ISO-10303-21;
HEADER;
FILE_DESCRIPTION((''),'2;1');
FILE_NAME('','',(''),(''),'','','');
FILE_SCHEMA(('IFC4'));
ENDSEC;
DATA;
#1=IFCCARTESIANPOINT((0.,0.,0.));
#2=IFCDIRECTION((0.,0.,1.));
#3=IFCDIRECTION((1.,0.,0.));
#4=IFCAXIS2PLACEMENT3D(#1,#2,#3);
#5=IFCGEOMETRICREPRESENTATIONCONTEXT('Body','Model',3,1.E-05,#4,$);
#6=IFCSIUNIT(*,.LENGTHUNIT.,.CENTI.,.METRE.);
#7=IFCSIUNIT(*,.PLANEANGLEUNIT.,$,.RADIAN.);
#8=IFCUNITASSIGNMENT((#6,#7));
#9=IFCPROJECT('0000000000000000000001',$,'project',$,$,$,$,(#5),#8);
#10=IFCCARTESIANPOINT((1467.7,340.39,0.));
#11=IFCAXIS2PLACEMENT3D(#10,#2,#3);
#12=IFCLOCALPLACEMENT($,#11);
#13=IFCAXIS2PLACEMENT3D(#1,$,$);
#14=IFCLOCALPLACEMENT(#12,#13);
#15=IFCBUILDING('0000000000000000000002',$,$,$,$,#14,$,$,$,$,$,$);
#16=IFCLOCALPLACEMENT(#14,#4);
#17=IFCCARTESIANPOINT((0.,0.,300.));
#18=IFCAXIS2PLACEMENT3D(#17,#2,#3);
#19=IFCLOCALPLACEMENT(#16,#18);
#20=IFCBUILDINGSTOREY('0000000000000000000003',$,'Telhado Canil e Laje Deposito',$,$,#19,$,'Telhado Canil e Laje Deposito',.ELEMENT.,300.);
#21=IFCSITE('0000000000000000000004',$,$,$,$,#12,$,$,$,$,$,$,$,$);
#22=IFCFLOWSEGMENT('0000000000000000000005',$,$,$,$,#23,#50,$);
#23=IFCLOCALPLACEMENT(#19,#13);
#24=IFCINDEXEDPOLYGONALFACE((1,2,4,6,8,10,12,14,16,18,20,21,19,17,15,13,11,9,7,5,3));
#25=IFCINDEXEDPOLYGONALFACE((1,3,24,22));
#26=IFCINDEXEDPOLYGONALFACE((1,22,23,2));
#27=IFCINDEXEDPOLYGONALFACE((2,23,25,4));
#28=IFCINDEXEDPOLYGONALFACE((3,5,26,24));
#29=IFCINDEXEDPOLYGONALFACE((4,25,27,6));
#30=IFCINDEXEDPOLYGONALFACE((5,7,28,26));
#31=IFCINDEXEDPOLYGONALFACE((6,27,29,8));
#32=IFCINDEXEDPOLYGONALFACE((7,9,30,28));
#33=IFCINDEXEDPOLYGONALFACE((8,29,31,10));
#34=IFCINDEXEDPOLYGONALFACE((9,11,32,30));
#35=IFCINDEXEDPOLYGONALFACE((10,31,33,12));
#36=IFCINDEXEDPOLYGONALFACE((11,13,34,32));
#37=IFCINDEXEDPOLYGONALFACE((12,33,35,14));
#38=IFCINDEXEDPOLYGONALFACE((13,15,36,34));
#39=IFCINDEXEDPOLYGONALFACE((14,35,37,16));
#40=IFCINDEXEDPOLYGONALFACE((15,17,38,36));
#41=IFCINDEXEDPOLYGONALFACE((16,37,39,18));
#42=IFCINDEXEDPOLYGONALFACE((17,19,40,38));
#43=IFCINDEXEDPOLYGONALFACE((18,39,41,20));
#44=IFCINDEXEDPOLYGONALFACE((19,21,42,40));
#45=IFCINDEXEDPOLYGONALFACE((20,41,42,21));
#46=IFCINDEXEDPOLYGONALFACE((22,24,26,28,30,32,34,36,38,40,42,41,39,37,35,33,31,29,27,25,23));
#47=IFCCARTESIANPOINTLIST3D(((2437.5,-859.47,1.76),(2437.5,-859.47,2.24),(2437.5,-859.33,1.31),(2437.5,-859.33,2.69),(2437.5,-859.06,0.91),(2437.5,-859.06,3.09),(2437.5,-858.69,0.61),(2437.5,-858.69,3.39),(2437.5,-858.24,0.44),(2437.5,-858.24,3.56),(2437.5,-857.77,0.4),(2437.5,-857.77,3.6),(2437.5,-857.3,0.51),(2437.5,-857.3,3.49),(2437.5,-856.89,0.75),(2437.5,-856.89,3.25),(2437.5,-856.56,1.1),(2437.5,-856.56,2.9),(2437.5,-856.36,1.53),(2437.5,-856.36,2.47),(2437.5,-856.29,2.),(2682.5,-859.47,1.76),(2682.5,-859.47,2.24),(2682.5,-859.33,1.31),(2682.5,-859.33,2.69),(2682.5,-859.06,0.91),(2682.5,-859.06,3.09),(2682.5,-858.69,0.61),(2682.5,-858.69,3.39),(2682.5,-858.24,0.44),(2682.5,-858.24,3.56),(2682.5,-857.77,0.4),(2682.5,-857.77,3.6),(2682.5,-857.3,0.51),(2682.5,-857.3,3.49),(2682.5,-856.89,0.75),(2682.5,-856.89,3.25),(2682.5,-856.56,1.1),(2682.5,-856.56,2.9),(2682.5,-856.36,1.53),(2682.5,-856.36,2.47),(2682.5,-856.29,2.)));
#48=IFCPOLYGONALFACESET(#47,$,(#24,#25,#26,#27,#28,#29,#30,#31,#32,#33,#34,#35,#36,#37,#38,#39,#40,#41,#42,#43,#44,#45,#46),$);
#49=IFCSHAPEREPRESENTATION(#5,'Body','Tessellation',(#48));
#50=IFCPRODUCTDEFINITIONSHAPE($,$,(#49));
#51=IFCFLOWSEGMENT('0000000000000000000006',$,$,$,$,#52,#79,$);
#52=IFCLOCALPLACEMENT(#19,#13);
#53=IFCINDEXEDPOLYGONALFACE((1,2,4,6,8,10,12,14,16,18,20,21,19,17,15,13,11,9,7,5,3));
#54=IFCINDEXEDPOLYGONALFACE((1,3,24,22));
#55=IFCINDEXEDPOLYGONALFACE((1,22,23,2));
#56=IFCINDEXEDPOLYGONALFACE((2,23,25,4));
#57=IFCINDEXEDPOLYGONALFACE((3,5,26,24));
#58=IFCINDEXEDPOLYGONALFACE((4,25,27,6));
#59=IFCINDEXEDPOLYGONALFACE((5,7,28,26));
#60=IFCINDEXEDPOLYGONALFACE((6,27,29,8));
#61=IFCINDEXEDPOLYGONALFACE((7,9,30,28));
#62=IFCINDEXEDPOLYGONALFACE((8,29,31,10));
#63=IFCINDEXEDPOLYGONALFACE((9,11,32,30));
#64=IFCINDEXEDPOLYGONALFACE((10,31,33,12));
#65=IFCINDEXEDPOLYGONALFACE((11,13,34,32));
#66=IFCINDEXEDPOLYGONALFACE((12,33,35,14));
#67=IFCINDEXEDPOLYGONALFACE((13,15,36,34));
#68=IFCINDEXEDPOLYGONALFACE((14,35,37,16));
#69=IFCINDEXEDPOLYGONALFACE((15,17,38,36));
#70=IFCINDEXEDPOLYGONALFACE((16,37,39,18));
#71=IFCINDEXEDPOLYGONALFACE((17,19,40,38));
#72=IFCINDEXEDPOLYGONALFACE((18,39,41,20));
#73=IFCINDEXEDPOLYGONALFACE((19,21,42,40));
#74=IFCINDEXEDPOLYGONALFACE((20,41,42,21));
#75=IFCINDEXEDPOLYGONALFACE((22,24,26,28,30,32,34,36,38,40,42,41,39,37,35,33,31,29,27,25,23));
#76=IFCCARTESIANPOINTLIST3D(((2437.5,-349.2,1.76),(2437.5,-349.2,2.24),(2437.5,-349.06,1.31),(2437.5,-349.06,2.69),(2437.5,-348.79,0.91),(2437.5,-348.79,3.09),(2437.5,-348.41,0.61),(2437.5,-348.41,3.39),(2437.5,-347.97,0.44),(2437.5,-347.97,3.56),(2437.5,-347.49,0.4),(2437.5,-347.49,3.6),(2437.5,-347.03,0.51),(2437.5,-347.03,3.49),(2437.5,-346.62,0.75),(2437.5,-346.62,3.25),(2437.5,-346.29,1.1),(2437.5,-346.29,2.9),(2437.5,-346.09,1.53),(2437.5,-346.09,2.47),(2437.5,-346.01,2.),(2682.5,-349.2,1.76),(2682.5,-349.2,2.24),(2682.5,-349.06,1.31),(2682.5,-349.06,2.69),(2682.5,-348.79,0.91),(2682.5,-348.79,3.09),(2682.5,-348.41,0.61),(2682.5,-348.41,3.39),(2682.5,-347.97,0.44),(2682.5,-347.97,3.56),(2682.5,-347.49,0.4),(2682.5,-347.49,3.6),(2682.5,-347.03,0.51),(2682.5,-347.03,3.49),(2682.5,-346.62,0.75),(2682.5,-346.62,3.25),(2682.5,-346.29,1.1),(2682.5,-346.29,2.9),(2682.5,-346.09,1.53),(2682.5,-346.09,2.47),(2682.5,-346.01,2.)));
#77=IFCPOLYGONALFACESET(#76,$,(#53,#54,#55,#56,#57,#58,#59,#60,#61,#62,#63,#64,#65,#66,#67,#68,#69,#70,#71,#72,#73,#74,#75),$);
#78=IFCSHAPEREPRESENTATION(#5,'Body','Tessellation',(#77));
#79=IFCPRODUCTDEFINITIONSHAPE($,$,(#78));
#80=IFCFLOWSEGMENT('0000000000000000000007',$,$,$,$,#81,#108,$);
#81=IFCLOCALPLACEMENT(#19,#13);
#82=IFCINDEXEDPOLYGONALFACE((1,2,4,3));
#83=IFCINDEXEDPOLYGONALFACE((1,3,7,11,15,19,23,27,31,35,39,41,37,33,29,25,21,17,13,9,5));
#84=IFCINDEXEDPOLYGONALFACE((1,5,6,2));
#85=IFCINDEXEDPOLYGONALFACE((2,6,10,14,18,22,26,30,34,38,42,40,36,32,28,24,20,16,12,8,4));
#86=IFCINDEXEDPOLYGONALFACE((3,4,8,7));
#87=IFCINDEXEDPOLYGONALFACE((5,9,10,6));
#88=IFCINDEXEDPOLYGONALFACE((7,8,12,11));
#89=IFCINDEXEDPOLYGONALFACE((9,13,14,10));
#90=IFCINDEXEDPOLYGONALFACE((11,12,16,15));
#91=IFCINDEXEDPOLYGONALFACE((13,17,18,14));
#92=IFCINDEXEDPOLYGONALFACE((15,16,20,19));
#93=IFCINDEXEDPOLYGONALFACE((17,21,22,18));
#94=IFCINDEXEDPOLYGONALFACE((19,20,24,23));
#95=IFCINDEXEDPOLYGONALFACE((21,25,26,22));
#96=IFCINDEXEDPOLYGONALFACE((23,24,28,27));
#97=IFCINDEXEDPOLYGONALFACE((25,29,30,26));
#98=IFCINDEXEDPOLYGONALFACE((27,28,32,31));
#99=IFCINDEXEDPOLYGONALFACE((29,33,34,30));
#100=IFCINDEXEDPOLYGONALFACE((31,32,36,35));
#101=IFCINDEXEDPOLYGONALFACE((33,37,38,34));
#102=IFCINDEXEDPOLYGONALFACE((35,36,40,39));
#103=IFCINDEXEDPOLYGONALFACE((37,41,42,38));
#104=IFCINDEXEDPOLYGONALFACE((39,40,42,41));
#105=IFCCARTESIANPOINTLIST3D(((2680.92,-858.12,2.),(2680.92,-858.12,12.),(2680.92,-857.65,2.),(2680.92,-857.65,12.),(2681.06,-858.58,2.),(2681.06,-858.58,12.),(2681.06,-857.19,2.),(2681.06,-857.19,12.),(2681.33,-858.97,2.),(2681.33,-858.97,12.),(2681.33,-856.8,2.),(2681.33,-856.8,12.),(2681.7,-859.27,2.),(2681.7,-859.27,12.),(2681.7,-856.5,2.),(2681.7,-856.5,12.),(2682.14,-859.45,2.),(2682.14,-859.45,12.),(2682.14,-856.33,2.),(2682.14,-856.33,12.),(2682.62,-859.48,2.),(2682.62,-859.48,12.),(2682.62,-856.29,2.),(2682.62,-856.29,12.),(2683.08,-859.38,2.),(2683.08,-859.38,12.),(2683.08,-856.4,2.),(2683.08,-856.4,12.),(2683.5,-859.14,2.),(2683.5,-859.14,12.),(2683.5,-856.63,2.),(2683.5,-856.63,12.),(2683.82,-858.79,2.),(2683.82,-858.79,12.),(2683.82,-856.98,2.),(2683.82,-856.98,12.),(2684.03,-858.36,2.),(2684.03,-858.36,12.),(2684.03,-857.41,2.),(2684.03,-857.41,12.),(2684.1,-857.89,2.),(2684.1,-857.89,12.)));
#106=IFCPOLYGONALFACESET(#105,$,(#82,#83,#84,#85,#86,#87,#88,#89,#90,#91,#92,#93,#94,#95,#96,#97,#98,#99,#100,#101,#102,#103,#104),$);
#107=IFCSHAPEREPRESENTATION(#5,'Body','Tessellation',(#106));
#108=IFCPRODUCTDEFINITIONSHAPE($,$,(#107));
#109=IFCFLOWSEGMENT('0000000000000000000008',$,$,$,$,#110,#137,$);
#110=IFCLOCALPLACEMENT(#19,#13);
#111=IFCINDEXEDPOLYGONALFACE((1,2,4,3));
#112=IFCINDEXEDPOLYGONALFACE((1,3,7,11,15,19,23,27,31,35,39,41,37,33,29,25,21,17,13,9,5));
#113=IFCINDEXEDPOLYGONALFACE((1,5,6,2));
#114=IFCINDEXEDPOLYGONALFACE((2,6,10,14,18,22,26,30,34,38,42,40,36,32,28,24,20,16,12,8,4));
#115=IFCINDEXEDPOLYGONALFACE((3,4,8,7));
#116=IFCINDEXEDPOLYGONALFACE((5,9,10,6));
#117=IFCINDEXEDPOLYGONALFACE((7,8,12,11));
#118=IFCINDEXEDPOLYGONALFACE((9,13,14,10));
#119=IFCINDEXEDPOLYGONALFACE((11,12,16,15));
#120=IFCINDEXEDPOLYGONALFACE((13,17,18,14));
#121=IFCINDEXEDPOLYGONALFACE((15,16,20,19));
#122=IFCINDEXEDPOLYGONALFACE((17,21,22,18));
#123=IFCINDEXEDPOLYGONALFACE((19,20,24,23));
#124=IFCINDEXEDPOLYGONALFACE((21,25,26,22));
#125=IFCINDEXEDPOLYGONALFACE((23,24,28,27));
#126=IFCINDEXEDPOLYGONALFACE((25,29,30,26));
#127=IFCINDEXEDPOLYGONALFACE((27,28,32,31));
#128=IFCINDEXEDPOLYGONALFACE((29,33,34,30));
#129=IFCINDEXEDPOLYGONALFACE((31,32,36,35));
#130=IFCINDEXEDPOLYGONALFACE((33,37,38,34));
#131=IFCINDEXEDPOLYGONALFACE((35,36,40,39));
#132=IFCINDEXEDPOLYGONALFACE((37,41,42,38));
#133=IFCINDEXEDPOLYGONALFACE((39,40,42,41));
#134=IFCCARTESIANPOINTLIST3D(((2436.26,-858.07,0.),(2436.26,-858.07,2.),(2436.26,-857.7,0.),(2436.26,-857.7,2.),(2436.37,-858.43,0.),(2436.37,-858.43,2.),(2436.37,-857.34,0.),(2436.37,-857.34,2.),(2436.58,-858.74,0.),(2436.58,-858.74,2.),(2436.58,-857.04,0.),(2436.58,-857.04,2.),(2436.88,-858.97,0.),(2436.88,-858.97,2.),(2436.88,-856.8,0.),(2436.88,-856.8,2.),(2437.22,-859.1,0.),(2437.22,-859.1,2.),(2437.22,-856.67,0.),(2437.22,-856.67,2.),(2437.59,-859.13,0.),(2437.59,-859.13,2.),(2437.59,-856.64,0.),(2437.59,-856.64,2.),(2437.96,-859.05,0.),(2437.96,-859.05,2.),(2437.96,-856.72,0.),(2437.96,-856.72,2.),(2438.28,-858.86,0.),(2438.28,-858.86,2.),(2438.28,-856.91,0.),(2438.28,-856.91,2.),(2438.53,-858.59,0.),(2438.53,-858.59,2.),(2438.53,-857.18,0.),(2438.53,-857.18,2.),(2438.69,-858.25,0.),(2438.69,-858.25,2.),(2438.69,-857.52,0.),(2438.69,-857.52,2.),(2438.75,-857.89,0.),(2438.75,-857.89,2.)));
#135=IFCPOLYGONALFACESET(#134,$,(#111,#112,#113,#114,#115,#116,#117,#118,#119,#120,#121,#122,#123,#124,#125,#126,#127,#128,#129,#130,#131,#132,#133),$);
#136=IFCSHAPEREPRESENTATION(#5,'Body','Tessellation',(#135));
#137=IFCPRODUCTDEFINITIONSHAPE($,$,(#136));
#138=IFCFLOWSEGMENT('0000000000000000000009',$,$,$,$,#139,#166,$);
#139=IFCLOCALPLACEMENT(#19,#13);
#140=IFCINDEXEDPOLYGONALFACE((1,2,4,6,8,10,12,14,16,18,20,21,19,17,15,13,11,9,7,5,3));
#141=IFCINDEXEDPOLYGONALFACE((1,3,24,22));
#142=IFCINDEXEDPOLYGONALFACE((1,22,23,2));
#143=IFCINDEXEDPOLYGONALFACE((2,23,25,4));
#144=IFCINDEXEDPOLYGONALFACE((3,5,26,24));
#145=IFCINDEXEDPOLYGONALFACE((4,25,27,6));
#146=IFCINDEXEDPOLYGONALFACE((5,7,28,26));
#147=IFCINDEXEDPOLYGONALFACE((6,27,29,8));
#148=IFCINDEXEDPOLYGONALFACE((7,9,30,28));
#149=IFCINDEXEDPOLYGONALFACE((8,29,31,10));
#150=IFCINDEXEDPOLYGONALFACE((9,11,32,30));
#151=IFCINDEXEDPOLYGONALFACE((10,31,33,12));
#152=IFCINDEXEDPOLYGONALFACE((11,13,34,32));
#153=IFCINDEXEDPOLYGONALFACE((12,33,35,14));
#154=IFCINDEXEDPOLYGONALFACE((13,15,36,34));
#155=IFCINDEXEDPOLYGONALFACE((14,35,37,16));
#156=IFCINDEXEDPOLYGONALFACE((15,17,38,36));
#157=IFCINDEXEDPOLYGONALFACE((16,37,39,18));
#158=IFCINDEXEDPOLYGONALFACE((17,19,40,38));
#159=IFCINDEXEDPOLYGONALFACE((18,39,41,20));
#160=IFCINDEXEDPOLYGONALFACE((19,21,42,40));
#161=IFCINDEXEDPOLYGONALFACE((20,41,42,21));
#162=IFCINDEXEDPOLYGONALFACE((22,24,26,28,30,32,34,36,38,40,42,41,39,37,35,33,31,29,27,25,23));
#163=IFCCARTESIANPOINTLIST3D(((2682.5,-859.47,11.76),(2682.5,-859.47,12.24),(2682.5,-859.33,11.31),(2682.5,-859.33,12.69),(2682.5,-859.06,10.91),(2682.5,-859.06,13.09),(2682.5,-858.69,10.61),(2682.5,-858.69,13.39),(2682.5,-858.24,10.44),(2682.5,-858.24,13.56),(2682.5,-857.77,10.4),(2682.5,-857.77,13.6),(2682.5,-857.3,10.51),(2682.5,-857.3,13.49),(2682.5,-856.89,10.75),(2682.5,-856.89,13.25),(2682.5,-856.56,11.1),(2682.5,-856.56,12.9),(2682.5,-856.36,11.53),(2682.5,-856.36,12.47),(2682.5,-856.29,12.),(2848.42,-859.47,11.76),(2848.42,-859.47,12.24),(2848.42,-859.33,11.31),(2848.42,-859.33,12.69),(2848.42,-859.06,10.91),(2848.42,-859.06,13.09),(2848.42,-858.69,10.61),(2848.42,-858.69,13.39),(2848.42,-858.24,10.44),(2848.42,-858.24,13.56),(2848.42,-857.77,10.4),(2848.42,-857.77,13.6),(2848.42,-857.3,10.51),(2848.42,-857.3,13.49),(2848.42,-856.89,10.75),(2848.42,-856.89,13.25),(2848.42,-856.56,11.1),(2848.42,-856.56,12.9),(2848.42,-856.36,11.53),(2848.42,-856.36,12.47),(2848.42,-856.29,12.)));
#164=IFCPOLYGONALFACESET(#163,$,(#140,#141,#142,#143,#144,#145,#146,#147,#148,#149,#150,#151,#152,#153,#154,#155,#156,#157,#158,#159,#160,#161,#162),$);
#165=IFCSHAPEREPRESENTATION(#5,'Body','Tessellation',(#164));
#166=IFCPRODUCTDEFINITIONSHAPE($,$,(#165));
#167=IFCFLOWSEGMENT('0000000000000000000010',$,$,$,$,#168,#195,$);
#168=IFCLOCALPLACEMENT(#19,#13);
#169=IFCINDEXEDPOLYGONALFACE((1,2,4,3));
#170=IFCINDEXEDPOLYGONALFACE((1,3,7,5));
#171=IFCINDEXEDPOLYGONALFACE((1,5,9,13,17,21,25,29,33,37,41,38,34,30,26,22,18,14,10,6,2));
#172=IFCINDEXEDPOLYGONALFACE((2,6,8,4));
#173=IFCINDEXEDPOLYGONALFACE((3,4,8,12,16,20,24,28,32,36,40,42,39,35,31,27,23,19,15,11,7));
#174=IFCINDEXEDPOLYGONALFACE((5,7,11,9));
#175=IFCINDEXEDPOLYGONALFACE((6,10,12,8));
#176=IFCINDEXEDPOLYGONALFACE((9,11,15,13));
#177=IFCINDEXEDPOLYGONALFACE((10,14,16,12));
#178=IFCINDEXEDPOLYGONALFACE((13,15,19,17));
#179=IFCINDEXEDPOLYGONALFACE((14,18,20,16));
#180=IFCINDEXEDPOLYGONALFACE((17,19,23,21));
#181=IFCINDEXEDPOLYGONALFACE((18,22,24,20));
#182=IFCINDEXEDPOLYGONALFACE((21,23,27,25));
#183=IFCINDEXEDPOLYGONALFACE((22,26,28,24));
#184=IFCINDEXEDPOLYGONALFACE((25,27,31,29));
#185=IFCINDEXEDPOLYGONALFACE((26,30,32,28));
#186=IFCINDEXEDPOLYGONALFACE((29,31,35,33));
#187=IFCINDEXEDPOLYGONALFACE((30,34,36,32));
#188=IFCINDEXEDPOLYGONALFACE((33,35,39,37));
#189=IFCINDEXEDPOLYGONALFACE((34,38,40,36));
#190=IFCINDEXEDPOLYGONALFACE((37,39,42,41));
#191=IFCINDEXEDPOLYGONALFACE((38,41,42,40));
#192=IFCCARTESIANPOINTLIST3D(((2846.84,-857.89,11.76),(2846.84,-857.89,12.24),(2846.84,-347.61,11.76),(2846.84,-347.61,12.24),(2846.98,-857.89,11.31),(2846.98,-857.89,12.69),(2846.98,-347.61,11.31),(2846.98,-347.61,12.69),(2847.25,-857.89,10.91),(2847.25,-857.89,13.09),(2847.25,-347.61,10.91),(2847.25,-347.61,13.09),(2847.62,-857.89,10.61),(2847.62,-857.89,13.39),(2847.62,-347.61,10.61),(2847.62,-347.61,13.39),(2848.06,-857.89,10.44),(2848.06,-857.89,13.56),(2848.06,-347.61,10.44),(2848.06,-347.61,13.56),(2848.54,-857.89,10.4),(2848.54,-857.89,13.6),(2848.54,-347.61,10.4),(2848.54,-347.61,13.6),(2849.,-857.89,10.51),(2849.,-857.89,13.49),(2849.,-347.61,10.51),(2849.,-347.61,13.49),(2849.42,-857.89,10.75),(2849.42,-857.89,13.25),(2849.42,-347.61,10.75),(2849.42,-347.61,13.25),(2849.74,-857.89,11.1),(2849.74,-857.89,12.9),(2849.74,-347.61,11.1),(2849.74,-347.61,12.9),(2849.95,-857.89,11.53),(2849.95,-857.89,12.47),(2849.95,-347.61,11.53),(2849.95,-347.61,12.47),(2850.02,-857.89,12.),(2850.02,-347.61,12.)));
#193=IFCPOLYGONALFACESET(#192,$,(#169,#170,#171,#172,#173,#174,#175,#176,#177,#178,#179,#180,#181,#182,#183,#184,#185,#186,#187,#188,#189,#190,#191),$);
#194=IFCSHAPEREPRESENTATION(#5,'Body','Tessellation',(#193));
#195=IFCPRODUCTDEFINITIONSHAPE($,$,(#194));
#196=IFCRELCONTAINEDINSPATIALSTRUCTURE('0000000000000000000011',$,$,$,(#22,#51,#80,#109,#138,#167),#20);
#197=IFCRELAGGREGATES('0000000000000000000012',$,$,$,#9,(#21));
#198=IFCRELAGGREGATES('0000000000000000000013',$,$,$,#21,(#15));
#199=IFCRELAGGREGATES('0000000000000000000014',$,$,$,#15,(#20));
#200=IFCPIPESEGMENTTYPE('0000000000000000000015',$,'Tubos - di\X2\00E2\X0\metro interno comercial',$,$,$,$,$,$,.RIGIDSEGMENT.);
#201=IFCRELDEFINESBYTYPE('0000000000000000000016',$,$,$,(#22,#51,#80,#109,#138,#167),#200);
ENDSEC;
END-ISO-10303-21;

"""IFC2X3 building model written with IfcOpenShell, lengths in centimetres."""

from ifc_helpers import new_model, si_unit, frame, origin, origin_with_axes, origin_2d_with_axis, place, context, project, spatial, circle, extrude, type_object, element, save


model = new_model("IFC2X3")

# Units and contexts
model_context = context("Model", 3, precision=1e-05, world=origin_with_axes(), identifier="Body")
ifc_project = project(units=[si_unit("LENGTHUNIT", "METRE", prefix="CENTI"), si_unit("PLANEANGLEUNIT", "RADIAN")], contexts=[model_context])

# Site, building, storey
site_placement = place(None, frame((1467.7, 340.39, 0.0), z_axis=(0.0, 0.0, 1.0), x_axis=(1.0, 0.0, 0.0)))
site = spatial("IfcSite", under=ifc_project, at=site_placement)
building_placement = place(site_placement, origin())
building = spatial("IfcBuilding", under=site, at=building_placement)
placement = place(building_placement, origin_with_axes())
storey_placement = place(placement, frame((0.0, 0.0, 300.0), z_axis=(0.0, 0.0, 1.0), x_axis=(1.0, 0.0, 0.0)))
storey = spatial("IfcBuildingStorey", under=building, at=storey_placement, Name="Telhado Canil e Laje Deposito", LongName="Telhado Canil e Laje Deposito", CompositionType="ELEMENT", Elevation=300.0)

# Flow segments
pipe_segment_type_1 = type_object("IfcPipeSegmentType", Name="Tubos - diâmetro interno comercial", PredefinedType="RIGIDSEGMENT")
for number, where, z_axis, x_axis in (
    (1, (2560.0, -857.89, 3.6), (0.0, 0.0, 1.0), (1.0, 0.0, 0.0)),
    (2, (2560.0, -347.61, 3.6), (0.0, 0.0, 1.0), (1.0, 0.0, 0.0)),
):
    element("IfcFlowSegment", number, at=place(storey_placement, frame(where, z_axis=z_axis, x_axis=x_axis)), inside=storey, type_object=pipe_segment_type_1, context=model_context, shape_type="SolidModel", body=[
        extrude(circle(Radius=1.6, at=origin_2d_with_axis()), frame((122.5, 0.0, -1.6), z_axis=(-1.0, 0.0, 0.0), x_axis=(0.0, 1.0, 0.0)), (0.0, 0.0, 1.0), 245.0),
    ])
flow_segment_1_placement = place(storey_placement, frame((2682.5, -857.89, 12.0), z_axis=(0.0, 0.0, 1.0), x_axis=(1.0, 0.0, 0.0)))
element("IfcFlowSegment", 3, at=flow_segment_1_placement, inside=storey, type_object=pipe_segment_type_1, context=model_context, shape_type="SolidModel", body=[
    extrude(circle(Radius=1.6, at=origin_2d_with_axis()), frame((0.0, 0.0, 0.0), z_axis=(0.0, 0.0, -1.0), x_axis=(1.0, 0.0, 0.0)), (0.0, 0.0, 1.0), 10.0),
])
flow_segment_2_placement = place(storey_placement, frame((2437.5, -857.89, 2.0), z_axis=(0.0, 0.0, 1.0), x_axis=(1.0, 0.0, 0.0)))
element("IfcFlowSegment", 4, at=flow_segment_2_placement, inside=storey, type_object=pipe_segment_type_1, context=model_context, shape_type="SolidModel", body=[
    extrude(circle(Radius=1.25, at=origin_2d_with_axis()), frame((0.0, 0.0, 0.0), z_axis=(0.0, 0.0, -1.0), x_axis=(1.0, 0.0, 0.0)), (0.0, 0.0, 1.0), 2.0),
])
flow_segment_3_placement = place(storey_placement, frame((2765.46, -857.89, 13.6), z_axis=(0.0, 0.0, 1.0), x_axis=(1.0, 0.0, 0.0)))
element("IfcFlowSegment", 5, at=flow_segment_3_placement, inside=storey, type_object=pipe_segment_type_1, context=model_context, shape_type="SolidModel", body=[
    extrude(circle(Radius=1.6, at=origin_2d_with_axis()), frame((82.96, 0.0, -1.6), z_axis=(-1.0, 0.0, 0.0), x_axis=(0.0, 1.0, 0.0)), (0.0, 0.0, 1.0), 165.92),
])
flow_segment_4_placement = place(storey_placement, frame((2848.42, -602.75, 13.6), z_axis=(0.0, 0.0, 1.0), x_axis=(1.0, 0.0, 0.0)))
element("IfcFlowSegment", 6, at=flow_segment_4_placement, inside=storey, type_object=pipe_segment_type_1, context=model_context, shape_type="SolidModel", body=[
    extrude(circle(Radius=1.6, at=origin_2d_with_axis()), frame((0.0, -255.14, -1.6), z_axis=(0.0, 1.0, 0.0), x_axis=(1.0, 0.0, 0.0)), (0.0, 0.0, 1.0), 510.27),
])

save(model, "model.ifc")
